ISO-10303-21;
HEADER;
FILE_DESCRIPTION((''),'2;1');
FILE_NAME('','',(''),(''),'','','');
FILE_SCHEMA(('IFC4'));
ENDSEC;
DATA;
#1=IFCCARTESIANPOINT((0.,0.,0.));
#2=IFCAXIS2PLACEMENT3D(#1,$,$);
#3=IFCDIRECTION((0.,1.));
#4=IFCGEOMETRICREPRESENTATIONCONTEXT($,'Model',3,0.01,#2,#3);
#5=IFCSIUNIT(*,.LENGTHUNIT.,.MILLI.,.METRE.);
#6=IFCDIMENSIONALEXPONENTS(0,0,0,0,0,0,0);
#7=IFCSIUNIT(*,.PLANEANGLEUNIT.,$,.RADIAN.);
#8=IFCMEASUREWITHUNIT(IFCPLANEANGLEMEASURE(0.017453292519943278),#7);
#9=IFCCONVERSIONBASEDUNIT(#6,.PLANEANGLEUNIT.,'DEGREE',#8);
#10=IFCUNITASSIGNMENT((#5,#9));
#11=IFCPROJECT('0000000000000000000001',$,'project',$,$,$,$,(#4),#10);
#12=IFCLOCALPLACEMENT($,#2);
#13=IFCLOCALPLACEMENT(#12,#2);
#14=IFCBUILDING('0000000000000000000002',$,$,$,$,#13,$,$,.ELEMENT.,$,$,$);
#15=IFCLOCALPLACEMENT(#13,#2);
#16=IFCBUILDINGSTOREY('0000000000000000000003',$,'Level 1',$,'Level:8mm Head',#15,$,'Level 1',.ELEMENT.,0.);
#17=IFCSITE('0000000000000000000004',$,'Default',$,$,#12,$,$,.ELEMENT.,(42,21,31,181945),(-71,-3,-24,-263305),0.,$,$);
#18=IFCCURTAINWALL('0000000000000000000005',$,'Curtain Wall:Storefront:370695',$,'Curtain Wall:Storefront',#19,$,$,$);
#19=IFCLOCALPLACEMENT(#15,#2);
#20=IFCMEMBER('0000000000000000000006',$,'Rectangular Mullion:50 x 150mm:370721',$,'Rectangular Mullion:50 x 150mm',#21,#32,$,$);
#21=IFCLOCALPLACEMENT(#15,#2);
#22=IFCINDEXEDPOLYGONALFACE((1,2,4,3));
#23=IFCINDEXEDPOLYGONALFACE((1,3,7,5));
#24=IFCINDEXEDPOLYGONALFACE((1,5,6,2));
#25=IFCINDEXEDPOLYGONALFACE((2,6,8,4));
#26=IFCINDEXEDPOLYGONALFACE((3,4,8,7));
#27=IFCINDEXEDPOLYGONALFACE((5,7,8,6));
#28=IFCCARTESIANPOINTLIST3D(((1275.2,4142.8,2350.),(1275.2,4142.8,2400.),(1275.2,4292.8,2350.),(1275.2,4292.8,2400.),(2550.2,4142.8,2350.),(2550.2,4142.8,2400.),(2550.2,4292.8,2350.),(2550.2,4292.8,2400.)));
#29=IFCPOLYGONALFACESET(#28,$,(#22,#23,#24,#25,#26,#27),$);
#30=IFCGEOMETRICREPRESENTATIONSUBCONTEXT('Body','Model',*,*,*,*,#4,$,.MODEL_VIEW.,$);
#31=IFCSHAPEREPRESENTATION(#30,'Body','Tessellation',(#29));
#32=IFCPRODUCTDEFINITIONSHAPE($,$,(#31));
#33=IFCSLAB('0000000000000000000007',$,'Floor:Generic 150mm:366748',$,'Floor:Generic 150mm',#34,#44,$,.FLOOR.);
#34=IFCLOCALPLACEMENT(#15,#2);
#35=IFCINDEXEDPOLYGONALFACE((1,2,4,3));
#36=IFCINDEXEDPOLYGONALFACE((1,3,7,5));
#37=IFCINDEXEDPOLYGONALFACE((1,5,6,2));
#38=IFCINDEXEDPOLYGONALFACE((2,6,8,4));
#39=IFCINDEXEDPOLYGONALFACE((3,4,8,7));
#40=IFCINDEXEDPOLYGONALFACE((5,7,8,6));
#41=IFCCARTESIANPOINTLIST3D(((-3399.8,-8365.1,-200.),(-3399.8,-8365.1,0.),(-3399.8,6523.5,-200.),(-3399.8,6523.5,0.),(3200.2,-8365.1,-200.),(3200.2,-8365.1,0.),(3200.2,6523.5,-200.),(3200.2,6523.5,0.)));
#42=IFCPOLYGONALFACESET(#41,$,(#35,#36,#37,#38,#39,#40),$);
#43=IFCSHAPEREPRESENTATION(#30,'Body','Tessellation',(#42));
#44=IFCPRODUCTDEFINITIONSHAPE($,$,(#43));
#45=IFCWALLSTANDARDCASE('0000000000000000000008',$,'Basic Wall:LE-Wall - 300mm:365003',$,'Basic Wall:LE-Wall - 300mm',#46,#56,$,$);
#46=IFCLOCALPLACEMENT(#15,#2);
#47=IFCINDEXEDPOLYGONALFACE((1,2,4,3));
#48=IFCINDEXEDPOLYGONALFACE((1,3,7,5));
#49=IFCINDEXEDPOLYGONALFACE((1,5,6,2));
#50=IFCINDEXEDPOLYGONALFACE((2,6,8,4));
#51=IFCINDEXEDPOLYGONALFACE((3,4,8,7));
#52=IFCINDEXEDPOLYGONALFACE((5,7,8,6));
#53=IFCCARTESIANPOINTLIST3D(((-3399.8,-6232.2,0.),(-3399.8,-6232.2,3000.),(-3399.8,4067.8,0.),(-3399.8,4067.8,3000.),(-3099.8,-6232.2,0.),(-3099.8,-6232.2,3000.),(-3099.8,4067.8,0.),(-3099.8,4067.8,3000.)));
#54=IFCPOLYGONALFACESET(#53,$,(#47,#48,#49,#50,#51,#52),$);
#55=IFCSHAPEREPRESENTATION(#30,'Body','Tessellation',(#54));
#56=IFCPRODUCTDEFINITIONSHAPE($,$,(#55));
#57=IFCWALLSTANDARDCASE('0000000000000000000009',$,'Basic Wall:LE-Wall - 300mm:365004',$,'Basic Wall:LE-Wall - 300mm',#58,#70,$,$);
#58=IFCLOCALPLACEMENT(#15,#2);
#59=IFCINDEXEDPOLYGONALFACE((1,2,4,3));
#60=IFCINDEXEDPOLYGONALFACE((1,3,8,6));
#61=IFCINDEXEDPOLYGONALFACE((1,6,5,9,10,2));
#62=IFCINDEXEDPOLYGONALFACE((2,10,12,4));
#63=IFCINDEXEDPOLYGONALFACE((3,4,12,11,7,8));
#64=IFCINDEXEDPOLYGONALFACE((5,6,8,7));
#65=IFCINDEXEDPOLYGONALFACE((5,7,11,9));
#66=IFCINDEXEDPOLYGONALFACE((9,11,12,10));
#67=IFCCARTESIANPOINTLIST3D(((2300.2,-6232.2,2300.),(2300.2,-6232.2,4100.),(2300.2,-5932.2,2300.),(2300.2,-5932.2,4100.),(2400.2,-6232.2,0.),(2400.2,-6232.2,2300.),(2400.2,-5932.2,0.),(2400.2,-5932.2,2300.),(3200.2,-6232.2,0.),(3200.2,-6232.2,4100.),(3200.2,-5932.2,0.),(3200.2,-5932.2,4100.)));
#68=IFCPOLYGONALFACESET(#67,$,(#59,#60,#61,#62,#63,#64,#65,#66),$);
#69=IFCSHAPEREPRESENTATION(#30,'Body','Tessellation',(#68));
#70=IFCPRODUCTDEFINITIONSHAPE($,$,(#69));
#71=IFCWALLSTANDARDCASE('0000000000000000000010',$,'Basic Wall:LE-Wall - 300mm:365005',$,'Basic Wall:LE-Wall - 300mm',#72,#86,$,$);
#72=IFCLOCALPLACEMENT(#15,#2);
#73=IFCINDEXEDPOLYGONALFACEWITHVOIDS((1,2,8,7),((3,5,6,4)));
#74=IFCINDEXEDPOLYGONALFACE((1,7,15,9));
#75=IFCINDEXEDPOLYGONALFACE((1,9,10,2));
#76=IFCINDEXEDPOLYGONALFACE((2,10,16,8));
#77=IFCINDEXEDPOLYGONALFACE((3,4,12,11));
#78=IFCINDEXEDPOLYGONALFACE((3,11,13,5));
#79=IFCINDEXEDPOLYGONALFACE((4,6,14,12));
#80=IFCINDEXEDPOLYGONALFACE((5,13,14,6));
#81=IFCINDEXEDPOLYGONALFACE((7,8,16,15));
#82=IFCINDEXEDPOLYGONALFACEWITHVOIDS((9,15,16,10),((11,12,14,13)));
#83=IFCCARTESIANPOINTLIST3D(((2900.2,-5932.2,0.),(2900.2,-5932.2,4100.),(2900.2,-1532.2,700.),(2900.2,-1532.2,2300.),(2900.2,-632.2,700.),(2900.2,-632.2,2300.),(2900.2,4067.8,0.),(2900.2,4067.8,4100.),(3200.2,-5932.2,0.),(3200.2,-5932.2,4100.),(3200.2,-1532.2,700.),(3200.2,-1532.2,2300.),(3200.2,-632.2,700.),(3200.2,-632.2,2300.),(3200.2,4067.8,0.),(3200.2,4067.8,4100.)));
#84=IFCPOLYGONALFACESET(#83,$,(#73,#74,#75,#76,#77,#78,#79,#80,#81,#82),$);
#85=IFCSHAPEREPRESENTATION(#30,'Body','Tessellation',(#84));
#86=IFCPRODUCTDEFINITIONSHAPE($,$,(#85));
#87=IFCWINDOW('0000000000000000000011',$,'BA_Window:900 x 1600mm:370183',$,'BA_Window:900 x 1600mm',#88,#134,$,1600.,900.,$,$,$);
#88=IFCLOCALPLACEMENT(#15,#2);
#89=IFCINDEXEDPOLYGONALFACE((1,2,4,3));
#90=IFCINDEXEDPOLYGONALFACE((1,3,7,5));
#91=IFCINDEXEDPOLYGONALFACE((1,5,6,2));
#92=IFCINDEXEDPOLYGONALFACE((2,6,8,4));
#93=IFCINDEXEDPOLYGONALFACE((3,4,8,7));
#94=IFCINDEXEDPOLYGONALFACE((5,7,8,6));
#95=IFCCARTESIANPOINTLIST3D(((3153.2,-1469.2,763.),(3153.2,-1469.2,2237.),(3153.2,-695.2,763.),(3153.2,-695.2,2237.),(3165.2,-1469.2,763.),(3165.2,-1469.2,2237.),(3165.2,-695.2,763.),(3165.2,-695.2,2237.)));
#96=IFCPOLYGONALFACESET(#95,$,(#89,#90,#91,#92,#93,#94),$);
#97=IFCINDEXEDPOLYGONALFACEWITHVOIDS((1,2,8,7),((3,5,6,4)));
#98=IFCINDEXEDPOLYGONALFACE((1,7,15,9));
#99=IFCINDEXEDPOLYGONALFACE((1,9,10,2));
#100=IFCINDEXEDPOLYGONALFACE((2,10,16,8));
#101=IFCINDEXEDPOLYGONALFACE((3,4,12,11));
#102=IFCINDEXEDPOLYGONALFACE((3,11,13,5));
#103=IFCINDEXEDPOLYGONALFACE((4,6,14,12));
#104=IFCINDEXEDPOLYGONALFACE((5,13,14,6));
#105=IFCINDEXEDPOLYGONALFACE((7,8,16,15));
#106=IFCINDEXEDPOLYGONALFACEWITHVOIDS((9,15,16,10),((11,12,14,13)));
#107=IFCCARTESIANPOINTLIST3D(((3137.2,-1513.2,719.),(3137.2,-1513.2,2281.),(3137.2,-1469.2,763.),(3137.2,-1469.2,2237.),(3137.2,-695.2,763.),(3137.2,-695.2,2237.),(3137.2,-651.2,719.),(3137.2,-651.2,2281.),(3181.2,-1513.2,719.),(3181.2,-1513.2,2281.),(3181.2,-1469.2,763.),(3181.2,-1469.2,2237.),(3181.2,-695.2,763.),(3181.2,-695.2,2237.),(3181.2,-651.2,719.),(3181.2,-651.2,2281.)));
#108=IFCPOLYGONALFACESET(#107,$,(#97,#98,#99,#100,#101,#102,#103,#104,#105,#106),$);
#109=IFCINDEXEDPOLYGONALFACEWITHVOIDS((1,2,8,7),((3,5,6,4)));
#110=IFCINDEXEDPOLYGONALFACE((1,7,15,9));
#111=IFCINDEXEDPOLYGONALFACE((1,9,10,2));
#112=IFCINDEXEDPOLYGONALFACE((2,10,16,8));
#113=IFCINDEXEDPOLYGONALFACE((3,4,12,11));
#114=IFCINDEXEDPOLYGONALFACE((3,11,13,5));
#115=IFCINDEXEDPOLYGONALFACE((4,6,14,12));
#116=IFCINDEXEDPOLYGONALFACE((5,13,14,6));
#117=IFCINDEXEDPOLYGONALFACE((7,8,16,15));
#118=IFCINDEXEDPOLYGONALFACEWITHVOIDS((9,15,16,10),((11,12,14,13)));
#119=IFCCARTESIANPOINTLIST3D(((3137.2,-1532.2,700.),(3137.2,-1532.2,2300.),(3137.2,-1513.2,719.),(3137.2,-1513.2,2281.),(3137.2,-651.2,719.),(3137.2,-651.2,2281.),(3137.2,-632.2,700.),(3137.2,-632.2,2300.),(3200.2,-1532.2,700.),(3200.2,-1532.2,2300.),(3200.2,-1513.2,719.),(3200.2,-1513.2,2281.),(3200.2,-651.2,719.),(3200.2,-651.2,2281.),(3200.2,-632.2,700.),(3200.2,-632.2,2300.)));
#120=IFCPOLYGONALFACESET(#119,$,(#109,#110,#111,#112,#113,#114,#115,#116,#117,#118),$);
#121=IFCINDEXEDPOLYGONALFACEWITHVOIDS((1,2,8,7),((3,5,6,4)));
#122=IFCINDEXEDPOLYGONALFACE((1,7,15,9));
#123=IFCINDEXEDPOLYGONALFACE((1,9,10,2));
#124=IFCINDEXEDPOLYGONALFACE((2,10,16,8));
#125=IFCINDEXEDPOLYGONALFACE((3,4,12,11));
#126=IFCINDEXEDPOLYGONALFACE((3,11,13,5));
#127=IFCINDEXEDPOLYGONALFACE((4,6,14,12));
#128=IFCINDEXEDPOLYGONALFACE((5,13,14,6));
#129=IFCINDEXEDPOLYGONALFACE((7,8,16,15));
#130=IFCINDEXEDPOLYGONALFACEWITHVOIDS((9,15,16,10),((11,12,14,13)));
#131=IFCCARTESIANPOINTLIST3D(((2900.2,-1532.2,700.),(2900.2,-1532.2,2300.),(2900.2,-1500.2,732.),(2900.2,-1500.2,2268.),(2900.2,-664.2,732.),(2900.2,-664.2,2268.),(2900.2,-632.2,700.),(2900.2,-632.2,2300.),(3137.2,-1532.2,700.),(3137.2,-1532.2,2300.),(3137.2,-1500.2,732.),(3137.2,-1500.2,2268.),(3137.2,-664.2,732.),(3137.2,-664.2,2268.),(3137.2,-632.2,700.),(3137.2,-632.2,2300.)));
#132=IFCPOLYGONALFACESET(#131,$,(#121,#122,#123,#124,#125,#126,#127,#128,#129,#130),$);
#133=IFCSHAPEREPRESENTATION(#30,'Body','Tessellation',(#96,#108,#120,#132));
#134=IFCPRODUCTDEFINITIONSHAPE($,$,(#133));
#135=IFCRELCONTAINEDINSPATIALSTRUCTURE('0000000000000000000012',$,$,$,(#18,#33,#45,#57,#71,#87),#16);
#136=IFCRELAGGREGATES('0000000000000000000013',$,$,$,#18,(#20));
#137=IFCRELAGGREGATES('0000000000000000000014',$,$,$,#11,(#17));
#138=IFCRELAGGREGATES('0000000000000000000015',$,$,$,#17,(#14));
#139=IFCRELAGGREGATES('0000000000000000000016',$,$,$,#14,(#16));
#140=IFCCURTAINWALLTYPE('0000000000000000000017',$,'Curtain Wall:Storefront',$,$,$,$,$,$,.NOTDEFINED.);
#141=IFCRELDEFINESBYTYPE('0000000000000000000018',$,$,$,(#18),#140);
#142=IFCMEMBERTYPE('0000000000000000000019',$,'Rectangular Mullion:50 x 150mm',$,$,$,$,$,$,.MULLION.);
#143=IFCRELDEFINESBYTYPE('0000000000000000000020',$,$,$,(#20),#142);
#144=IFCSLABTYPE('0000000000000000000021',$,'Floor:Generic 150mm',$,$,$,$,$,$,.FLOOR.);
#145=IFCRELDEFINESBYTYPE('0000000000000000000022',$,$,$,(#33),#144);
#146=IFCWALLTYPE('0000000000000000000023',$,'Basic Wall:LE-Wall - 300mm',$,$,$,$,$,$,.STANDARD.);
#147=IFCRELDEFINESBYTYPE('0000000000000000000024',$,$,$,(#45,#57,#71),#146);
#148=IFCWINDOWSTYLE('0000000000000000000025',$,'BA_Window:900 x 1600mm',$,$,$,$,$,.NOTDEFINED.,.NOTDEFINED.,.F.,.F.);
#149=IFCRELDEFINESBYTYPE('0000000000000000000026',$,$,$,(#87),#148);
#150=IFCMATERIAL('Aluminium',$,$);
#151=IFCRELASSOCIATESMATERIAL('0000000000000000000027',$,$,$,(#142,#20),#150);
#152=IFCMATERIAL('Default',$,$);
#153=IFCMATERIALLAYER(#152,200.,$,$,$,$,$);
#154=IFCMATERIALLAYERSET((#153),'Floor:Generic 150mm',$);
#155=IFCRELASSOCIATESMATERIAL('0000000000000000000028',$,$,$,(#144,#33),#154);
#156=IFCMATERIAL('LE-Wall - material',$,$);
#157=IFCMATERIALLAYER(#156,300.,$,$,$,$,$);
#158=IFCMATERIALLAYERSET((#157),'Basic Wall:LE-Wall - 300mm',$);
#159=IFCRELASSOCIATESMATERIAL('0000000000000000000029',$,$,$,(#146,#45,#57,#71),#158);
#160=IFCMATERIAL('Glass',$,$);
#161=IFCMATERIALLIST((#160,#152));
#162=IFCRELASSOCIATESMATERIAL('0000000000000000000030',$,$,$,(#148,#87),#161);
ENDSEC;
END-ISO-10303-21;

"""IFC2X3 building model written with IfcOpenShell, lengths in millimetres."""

from ifc_helpers import new_model, entity, si_unit, converted_unit, direction, frame, frame_2d, origin, origin_2d_with_axis, place, context, subcontext, project, spatial, polyline, rectangle, outline, extrude, clip, bounded_halfspace, source, transform, mapped, material, material_list, layer, layer_set, layer_usage, type_object, type_shapes, element, fill, aggregate, save


model = new_model("IFC2X3")

# Units and contexts
model_context = context("Model", 3, precision=0.01, world=origin(), true_north=direction((0.0, 1.0)))
body_context = subcontext(model_context, "Body", "Model", "MODEL_VIEW")
ifc_project = project(units=[si_unit("LENGTHUNIT", "METRE", prefix="MILLI"), converted_unit("PLANEANGLEUNIT", "DEGREE", entity("IfcPlaneAngleMeasure", 0.017453292519943278), si_unit("PLANEANGLEUNIT", "RADIAN"), dimensions=[0, 0, 0, 0, 0, 0, 0])], contexts=[model_context])

# Site, building, storey
site_placement = place(None, origin())
site = spatial("IfcSite", under=ifc_project, at=site_placement, Name="Default", CompositionType="ELEMENT", RefLatitude=(42, 21, 31, 181945), RefLongitude=(-71, -3, -24, -263305), RefElevation=0.0)
building_placement = place(site_placement, origin())
building = spatial("IfcBuilding", under=site, at=building_placement, CompositionType="ELEMENT")
storey_placement = place(building_placement, origin())
storey = spatial("IfcBuildingStorey", under=building, at=storey_placement, Name="Level 1", ObjectType="Level:8mm Head", LongName="Level 1", CompositionType="ELEMENT", Elevation=0.0)

# Shared definitions
ifc_material_1 = material(Name="Default")

# Curtain wall, member
curtain_wall_type = type_object("IfcCurtainWallType", Name="Curtain Wall:Storefront", PredefinedType="NOTDEFINED")
curtain_wall_placement = place(storey_placement, origin())
curtain_wall = element("IfcCurtainWall", 1, at=curtain_wall_placement, inside=storey, type_object=curtain_wall_type, Name="Curtain Wall:Storefront:370695", ObjectType="Curtain Wall:Storefront")
ifc_material_2 = material(Name="Aluminium")
member_type_1 = type_object("IfcMemberType", Name="Rectangular Mullion:50 x 150mm", PredefinedType="MULLION", material=ifc_material_2)
shared_shape_1 = source(origin(), body_context, "Body", "SweptSolid", [
    extrude(rectangle(XDim=50.0, YDim=150.0, at=origin_2d_with_axis()), frame((-25.0, 0.0, -1275.0), z_axis=(0.0, 0.0, 1.0), x_axis=(-1.0, 0.0, 0.0)), (0.0, 0.0, 1.0), 1275.0),
])
type_shapes(member_type_1, [shared_shape_1])
member_1_placement = place(curtain_wall_placement, frame((2550.2, 4217.8, 2400.0), z_axis=(1.0, 0.0, 0.0), x_axis=(0.0, 0.0, 1.0)))
member_1 = element("IfcMember", 2, at=member_1_placement, type_object=member_type_1, material=ifc_material_2, Name="Rectangular Mullion:50 x 150mm:370721", ObjectType="Rectangular Mullion:50 x 150mm", context=body_context, shape_type="MappedRepresentation", body=[
    mapped(shared_shape_1, transform((0.0, 0.0, 0.0), scale=1.0)),
])
aggregate(curtain_wall, [member_1])

# Slab
ifc_layer_1 = layer(ifc_material_1, 200.0)
ifc_layer_set_1 = layer_set([ifc_layer_1], Name="Floor:Generic 150mm")
ifc_layer_usage_1 = layer_usage(ifc_layer_set_1, "AXIS3", "POSITIVE", 0.0)
slab_type = type_object("IfcSlabType", Name="Floor:Generic 150mm", PredefinedType="FLOOR", material=ifc_layer_set_1)
slab_placement = place(storey_placement, origin())
element("IfcSlab", 3, at=slab_placement, inside=storey, type_object=slab_type, material=ifc_layer_usage_1, Name="Floor:Generic 150mm:366748", ObjectType="Floor:Generic 150mm", PredefinedType="FLOOR", context=body_context, shape_type="SweptSolid", body=[
    extrude(rectangle(XDim=14888.7, YDim=6600.0, at=origin_2d_with_axis()), frame((-99.8, -920.8, 0.0), z_axis=(0.0, 0.0, -1.0), x_axis=(0.0, 1.0, 0.0)), (0.0, 0.0, 1.0), 200.0),
])

# Wall
ifc_material_3 = material(Name="LE-Wall - material")
ifc_layer_2 = layer(ifc_material_3, 300.0)
ifc_layer_set_2 = layer_set([ifc_layer_2], Name="Basic Wall:LE-Wall - 300mm")
ifc_layer_usage_2 = layer_usage(ifc_layer_set_2, "AXIS2", "NEGATIVE", 150.0)
wall_type_1 = type_object("IfcWallType", Name="Basic Wall:LE-Wall - 300mm", PredefinedType="STANDARD", material=ifc_layer_set_2)
wall_1_placement = place(storey_placement, frame((-3249.8, -6232.2, 0.0), z_axis=(0.0, 0.0, 1.0), x_axis=(0.0, 1.0, 0.0)))
element("IfcWallStandardCase", 4, at=wall_1_placement, inside=storey, type_object=wall_type_1, material=ifc_layer_usage_2, Name="Basic Wall:LE-Wall - 300mm:365003", ObjectType="Basic Wall:LE-Wall - 300mm", context=body_context, shape_type="Clipping", body=[
    clip(extrude(rectangle(XDim=10300.0, YDim=300.0, at=frame_2d((5150.0, 0.0), x_axis=(-1.0, 0.0))), origin(), (0.0, 0.0, 1.0), 3000.0), bounded_halfspace(frame((0.0, -150.0, 3000.0), z_axis=(0.0, 0.0, -1.0), x_axis=(-1.0, 0.0, 0.0)), True, frame((0.0, -150.0, 3000.0)), polyline([(0.0, 0.0), (300.0, 0.0), (1650.0, 0.0), (5650.0, 0.0), (10300.0, 0.0), (10300.0, 300.0), (0.0, 300.0), (0.0, 0.0)]))),
])

# Wall, opening
ifc_layer_usage_3 = layer_usage(ifc_layer_set_2, "AXIS2", "NEGATIVE", 150.0)
wall_2_placement = place(storey_placement, frame((3200.2, -6082.2, 0.0), z_axis=(0.0, 0.0, 1.0), x_axis=(-1.0, 0.0, 0.0)))
wall_2 = element("IfcWallStandardCase", 5, at=wall_2_placement, inside=storey, type_object=wall_type_1, material=ifc_layer_usage_3, Name="Basic Wall:LE-Wall - 300mm:365004", ObjectType="Basic Wall:LE-Wall - 300mm", context=body_context, shape_type="SweptSolid", body=[
    extrude(rectangle(XDim=900.0, YDim=300.0, at=frame_2d((450.0, 0.0), x_axis=(-1.0, 0.0))), origin(), (0.0, 0.0, 1.0), 4100.0),
])
opening_1_placement = place(wall_2_placement, origin())
element("IfcOpeningElement", 6, at=opening_1_placement, cuts=wall_2, ObjectType="Opening", context=body_context, shape_type="SweptSolid", body=[
    extrude(rectangle(XDim=2300.0, YDim=900.0, at=frame_2d((0.0, 0.0), x_axis=(0.0, 1.0))), frame((1250.0, -1374.0, 1150.0), z_axis=(0.0, 1.0, 0.0), x_axis=(-1.0, 0.0, 0.0)), (0.0, 0.0, 1.0), 3048.0),
])

# Wall, opening, window
ifc_layer_usage_4 = layer_usage(ifc_layer_set_2, "AXIS2", "NEGATIVE", 150.0)
wall_3_placement = place(storey_placement, frame((3050.2, 4067.8, 0.0), z_axis=(0.0, 0.0, 1.0), x_axis=(0.0, -1.0, 0.0)))
wall_3 = element("IfcWallStandardCase", 7, at=wall_3_placement, inside=storey, type_object=wall_type_1, material=ifc_layer_usage_4, Name="Basic Wall:LE-Wall - 300mm:365005", ObjectType="Basic Wall:LE-Wall - 300mm", context=body_context, shape_type="SweptSolid", body=[
    extrude(rectangle(XDim=10000.0, YDim=300.0, at=frame_2d((5000.0, 0.0), x_axis=(-1.0, 0.0))), origin(), (0.0, 0.0, 1.0), 4100.0),
])
opening_2_placement = place(wall_3_placement, frame((4700.0, -150.0, 700.0)))
opening_2 = element("IfcOpeningElement", 8, at=opening_2_placement, cuts=wall_3, ObjectType="Opening", context=body_context, shape_type="SweptSolid", body=[
    extrude(rectangle(XDim=1600.0, YDim=900.0, at=frame_2d((800.0, 450.0), x_axis=(1.0, 0.0))), frame((0.0, 0.0, 0.0), z_axis=(0.0, 1.0, 0.0), x_axis=(0.0, 0.0, 1.0)), (0.0, 0.0, 1.0), 300.0),
])
ifc_material_4 = material(Name="Glass")
ifc_material_list = material_list([ifc_material_4, ifc_material_1])
window_style = type_object("IfcWindowStyle", Name="BA_Window:900 x 1600mm", ConstructionType="NOTDEFINED", OperationType="NOTDEFINED", ParameterTakesPrecedence=False, Sizeable=False, material=ifc_material_list)
shared_shape_2 = source(origin(), body_context, "Body", "SweptSolid", [
    extrude(rectangle(XDim=12.0, YDim=774.0, at=frame_2d((0.0, 0.0), x_axis=(1.0, 0.0))), frame((450.0, 259.0, 63.0), z_axis=(0.0, 0.0, 1.0), x_axis=(0.0, -1.0, 0.0)), (0.0, 0.0, 1.0), 1474.0),
    extrude(outline(polyline([(-431.0, -781.0), (431.0, -781.0), (431.0, 781.0), (-431.0, 781.0), (-431.0, -781.0)]), holes=[polyline([(-387.0, -737.0), (-387.0, 737.0), (387.0, 737.0), (387.0, -737.0), (-387.0, -737.0)])]), frame((450.0, 237.0, 800.0), z_axis=(0.0, 1.0, 0.0), x_axis=(1.0, 0.0, 0.0)), (0.0, 0.0, 1.0), 44.0),
    extrude(outline(polyline([(-450.0, -800.0), (450.0, -800.0), (450.0, 800.0), (-450.0, 800.0), (-450.0, -800.0)]), holes=[polyline([(-431.0, -781.0), (-431.0, 781.0), (431.0, 781.0), (431.0, -781.0), (-431.0, -781.0)])]), frame((450.0, 237.0, 800.0), z_axis=(0.0, 1.0, 0.0), x_axis=(1.0, 0.0, 0.0)), (0.0, 0.0, 1.0), 63.0),
    extrude(outline(polyline([(-450.0, -800.0), (450.0, -800.0), (450.0, 800.0), (-450.0, 800.0), (-450.0, -800.0)]), holes=[polyline([(-418.0, -768.0), (-418.0, 768.0), (418.0, 768.0), (418.0, -768.0), (-418.0, -768.0)])]), frame((450.0, 0.0, 800.0), z_axis=(0.0, 1.0, 0.0), x_axis=(1.0, 0.0, 0.0)), (0.0, 0.0, 1.0), 237.0),
])
type_shapes(window_style, [shared_shape_2])
window_1_placement = place(opening_2_placement, origin())
window_1 = element("IfcWindow", 9, at=window_1_placement, inside=storey, type_object=window_style, material=ifc_material_list, Name="BA_Window:900 x 1600mm:370183", ObjectType="BA_Window:900 x 1600mm", OverallHeight=1600.0, OverallWidth=900.0, context=body_context, shape_type="MappedRepresentation", body=[
    mapped(shared_shape_2, transform((0.0, 0.0, 0.0), scale=1.0)),
])
fill(opening_2, window_1)

save(model, "model.ifc")
